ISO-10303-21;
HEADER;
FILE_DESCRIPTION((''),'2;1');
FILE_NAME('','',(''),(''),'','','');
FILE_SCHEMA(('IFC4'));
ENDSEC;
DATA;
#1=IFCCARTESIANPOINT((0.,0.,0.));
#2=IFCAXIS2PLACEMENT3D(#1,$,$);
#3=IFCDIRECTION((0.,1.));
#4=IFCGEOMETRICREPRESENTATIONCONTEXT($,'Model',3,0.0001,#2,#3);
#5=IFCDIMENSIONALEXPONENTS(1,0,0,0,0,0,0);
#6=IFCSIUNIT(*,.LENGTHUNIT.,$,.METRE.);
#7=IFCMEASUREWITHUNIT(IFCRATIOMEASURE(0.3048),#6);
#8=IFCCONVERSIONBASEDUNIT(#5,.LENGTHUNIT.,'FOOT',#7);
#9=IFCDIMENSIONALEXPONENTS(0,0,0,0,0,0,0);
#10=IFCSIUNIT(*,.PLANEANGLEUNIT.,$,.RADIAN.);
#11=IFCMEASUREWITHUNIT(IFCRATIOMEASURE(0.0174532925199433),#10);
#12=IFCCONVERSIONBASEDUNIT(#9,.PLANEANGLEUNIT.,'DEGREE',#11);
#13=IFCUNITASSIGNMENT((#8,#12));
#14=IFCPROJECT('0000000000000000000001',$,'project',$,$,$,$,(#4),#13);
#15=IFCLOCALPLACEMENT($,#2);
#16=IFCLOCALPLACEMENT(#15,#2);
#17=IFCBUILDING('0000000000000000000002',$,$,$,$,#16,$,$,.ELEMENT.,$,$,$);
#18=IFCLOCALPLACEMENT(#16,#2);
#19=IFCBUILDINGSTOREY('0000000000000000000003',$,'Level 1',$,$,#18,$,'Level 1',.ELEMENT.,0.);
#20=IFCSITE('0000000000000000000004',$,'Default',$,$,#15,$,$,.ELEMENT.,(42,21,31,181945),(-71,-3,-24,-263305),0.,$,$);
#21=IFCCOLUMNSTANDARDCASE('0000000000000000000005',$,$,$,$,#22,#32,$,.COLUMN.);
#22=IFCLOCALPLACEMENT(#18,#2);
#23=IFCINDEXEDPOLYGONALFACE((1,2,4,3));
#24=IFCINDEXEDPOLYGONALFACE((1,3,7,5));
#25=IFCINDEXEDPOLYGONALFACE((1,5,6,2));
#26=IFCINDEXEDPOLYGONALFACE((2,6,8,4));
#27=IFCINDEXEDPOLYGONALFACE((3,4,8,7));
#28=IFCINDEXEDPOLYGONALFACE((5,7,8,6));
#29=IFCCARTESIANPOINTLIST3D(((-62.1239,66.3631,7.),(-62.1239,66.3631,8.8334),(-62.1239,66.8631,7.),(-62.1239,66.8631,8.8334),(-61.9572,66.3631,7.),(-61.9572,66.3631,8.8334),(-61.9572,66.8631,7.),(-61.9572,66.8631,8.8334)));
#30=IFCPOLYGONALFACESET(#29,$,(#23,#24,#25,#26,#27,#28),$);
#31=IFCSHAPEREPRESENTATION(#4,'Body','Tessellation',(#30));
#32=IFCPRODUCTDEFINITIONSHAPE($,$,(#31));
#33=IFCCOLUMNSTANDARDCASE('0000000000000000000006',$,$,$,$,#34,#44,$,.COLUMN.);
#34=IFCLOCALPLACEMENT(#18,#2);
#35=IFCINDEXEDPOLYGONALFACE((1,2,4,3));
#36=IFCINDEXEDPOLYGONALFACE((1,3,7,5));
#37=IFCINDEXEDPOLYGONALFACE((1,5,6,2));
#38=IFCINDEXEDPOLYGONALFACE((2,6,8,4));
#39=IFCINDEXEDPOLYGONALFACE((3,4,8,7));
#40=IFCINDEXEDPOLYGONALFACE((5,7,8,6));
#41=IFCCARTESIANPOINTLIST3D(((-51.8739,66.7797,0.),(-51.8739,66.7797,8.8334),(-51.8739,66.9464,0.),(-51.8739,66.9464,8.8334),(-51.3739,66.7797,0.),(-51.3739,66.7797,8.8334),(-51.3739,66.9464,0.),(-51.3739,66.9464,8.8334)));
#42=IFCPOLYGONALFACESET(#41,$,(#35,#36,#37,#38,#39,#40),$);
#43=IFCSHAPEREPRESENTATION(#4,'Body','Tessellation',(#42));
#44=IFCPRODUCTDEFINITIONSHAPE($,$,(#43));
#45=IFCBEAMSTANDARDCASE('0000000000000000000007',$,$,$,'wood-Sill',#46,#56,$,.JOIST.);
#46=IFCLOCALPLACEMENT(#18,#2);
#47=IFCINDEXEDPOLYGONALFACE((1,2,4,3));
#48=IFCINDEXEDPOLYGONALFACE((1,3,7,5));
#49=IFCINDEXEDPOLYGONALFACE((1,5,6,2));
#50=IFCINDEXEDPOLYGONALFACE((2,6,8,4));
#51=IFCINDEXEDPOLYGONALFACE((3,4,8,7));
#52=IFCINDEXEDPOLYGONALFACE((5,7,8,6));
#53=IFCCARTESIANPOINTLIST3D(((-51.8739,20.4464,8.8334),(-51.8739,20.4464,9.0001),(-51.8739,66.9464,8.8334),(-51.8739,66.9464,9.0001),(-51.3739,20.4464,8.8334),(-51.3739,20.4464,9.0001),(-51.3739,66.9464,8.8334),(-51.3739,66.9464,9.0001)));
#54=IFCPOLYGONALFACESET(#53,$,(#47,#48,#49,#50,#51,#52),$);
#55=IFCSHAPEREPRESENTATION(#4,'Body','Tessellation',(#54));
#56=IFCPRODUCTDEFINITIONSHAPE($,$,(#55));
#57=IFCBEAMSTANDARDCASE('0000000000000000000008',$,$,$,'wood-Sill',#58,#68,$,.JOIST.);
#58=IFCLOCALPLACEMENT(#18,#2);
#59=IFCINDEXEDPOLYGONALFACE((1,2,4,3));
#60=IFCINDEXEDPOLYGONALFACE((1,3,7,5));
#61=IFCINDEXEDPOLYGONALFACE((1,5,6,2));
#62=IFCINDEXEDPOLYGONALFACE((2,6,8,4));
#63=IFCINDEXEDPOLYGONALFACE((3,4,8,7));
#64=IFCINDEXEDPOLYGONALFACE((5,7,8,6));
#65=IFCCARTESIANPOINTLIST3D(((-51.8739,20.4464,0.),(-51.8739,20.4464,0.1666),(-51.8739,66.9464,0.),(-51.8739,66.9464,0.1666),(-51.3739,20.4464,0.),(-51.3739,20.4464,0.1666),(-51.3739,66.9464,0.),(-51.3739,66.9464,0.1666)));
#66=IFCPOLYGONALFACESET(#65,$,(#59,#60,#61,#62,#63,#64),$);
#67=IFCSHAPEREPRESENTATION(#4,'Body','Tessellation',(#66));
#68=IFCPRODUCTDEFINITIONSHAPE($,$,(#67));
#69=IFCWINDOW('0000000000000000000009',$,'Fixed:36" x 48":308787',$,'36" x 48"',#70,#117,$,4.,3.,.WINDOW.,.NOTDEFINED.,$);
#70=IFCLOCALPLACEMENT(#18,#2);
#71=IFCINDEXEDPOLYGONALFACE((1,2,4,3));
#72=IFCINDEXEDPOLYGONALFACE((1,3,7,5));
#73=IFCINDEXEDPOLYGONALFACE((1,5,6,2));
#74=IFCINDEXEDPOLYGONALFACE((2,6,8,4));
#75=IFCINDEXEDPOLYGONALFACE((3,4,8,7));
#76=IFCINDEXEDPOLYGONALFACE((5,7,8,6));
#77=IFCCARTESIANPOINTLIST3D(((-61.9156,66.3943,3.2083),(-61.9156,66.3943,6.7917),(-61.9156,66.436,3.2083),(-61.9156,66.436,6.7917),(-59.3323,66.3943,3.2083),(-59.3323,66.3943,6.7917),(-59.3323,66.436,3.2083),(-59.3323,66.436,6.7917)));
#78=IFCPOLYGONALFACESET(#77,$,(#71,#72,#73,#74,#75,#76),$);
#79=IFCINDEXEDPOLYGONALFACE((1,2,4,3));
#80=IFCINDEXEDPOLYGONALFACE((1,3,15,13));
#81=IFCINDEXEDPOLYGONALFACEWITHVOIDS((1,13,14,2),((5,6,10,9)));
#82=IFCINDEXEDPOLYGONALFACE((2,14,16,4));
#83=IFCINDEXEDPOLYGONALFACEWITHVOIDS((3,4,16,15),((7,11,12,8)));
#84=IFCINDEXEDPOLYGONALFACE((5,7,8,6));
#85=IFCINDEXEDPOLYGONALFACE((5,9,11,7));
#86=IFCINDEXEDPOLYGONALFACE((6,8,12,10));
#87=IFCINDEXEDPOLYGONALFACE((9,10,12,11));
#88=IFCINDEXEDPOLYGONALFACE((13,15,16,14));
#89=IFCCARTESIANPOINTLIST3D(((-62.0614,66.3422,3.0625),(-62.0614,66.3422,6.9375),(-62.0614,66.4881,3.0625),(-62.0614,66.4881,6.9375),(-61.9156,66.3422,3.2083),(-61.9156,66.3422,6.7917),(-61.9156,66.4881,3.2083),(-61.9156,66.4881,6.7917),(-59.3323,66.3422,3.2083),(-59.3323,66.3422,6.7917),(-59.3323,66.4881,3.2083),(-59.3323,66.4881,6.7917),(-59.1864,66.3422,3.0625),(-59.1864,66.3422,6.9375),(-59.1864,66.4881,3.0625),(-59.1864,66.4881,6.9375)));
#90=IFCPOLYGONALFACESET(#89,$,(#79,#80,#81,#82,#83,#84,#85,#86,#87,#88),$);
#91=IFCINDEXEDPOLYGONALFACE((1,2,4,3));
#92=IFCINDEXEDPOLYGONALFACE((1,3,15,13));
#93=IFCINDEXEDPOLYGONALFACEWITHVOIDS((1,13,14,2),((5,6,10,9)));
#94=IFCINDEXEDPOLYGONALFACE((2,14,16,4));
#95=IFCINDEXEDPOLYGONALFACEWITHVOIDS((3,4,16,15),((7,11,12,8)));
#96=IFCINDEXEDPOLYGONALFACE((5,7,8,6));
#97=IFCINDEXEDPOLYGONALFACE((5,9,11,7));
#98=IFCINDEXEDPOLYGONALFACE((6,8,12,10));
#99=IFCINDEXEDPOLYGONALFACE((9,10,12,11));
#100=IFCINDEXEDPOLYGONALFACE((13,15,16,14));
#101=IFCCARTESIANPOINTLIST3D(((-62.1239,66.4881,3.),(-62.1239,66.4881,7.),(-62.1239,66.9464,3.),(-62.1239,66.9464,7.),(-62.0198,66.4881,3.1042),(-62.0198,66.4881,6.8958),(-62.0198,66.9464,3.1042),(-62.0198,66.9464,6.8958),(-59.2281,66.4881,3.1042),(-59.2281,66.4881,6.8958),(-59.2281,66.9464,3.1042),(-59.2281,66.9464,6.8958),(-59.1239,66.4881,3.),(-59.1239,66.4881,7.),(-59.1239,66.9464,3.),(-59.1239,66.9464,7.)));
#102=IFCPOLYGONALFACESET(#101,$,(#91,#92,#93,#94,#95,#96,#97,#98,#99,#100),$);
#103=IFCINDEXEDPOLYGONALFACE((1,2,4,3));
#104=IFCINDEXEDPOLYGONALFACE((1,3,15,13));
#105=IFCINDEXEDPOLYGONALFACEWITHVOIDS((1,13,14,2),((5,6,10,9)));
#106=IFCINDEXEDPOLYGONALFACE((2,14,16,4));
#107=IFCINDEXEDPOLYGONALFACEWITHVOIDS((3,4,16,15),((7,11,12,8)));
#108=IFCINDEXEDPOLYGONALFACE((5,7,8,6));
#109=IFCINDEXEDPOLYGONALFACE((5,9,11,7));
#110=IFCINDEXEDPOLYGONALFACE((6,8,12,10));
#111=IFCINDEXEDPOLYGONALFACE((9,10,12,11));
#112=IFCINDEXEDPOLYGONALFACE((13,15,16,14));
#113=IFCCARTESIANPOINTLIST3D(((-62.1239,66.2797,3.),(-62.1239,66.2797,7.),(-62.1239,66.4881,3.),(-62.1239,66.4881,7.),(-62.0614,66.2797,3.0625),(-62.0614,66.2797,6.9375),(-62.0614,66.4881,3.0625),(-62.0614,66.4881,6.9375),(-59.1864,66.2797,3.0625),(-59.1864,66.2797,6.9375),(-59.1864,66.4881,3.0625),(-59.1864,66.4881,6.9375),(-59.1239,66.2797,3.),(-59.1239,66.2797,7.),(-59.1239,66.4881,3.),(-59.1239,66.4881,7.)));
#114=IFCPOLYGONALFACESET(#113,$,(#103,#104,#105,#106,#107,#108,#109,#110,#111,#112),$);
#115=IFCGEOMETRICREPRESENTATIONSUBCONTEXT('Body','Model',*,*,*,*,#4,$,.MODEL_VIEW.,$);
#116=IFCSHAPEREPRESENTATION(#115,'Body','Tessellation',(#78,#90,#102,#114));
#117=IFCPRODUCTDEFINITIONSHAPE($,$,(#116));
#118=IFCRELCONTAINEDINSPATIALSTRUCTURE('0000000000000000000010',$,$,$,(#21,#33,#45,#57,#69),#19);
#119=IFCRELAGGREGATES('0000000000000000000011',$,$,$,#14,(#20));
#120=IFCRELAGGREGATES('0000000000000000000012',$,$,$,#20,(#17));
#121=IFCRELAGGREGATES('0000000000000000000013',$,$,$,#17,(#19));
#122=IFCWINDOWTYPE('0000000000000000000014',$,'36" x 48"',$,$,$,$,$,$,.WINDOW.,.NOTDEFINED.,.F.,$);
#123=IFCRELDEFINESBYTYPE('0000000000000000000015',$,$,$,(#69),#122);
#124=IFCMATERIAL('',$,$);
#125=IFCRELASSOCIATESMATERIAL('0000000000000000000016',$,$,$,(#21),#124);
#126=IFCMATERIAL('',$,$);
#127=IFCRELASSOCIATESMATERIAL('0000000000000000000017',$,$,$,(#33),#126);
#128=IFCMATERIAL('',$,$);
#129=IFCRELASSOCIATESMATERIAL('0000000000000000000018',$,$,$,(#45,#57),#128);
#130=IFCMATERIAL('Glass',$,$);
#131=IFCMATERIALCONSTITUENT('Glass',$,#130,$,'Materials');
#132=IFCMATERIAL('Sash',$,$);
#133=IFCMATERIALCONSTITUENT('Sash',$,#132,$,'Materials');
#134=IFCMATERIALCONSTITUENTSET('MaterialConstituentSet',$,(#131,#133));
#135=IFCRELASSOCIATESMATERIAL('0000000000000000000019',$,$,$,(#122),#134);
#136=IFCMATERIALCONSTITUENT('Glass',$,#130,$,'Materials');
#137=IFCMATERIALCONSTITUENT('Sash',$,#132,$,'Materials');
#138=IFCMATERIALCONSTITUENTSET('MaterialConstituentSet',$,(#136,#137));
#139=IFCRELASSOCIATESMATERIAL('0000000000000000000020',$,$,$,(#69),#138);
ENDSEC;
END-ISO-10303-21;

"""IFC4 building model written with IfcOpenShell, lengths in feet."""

from ifc_helpers import new_model, entity, si_unit, converted_unit, direction, frame, frame_2d, origin, origin_with_axes, place, context, subcontext, project, spatial, polyline, rectangle, outline, extrude, source, transform, mapped, material, constituent, constituent_set, type_object, type_shapes, element, save


model = new_model("IFC4")

# Units and contexts
model_context = context("Model", 3, precision=0.0001, world=origin(), true_north=direction((0.0, 1.0)))
body_context = subcontext(model_context, "Body", "Model", "MODEL_VIEW")
ifc_project = project(units=[converted_unit("LENGTHUNIT", "FOOT", entity("IfcRatioMeasure", 0.3048), si_unit("LENGTHUNIT", "METRE"), dimensions=[1, 0, 0, 0, 0, 0, 0]), converted_unit("PLANEANGLEUNIT", "DEGREE", entity("IfcRatioMeasure", 0.0174532925199433), si_unit("PLANEANGLEUNIT", "RADIAN"), dimensions=[0, 0, 0, 0, 0, 0, 0])], contexts=[model_context])

# Site, building, storey
site_placement = place(None, origin())
site = spatial("IfcSite", under=ifc_project, at=site_placement, Name="Default", CompositionType="ELEMENT", RefLatitude=(42, 21, 31, 181945), RefLongitude=(-71, -3, -24, -263305), RefElevation=0.0)
building_placement = place(site_placement, origin())
building = spatial("IfcBuilding", under=site, at=building_placement, CompositionType="ELEMENT")
storey_placement = place(building_placement, origin())
storey = spatial("IfcBuildingStorey", under=building, at=storey_placement, Name="Level 1", LongName="Level 1", CompositionType="ELEMENT", Elevation=0.0)

# Columns
ifc_material_1 = material(Name="")
placement_1 = place(storey_placement, frame((-69.9573, 66.6131, 0.0)))
ifc_material_2 = material(Name="")
for number, where, z_axis, x_axis in (
    (1, (7.9167, 0.0, 7.0), (0.0, 0.0, 1.0), (1.0, 0.0, 0.0)),
):
    element("IfcColumnStandardCase", number, at=place(placement_1, frame(where, z_axis=z_axis, x_axis=x_axis)), inside=storey, material=ifc_material_2, PredefinedType="COLUMN", context=model_context, shape_type="SweptSolid", body=[
        extrude(rectangle(XDim=0.1667, YDim=0.5), origin(), (0.0, 0.0, 1.0), 1.8334),
    ])
placement_2 = place(storey_placement, frame((-51.6239, 66.9464, 0.0), z_axis=(0.0, 0.0, 1.0), x_axis=(0.0, -1.0, 0.0)))
for number, where, z_axis, x_axis in (
    (2, (0.0833, 0.0, 0.0), (0.0, 0.0, 1.0), (1.0, 0.0, 0.0)),
):
    element("IfcColumnStandardCase", number, at=place(placement_2, frame(where, z_axis=z_axis, x_axis=x_axis)), inside=storey, material=ifc_material_1, PredefinedType="COLUMN", context=model_context, shape_type="SweptSolid", body=[
        extrude(rectangle(XDim=0.1667, YDim=0.5), origin(), (0.0, 0.0, 1.0), 8.8334),
    ])

# Beams
ifc_material_3 = material(Name="")
for number, where, z_axis, x_axis in (
    (3, (0.0, 0.0, 8.9167), (1.0, 0.0, 0.0), (0.0, 0.0, 1.0)),
    (4, (0.0, 0.0, 0.0833), (1.0, 0.0, 0.0), (0.0, 0.0, 1.0)),
):
    element("IfcBeamStandardCase", number, at=place(placement_2, frame(where, z_axis=z_axis, x_axis=x_axis)), inside=storey, material=ifc_material_3, ObjectType="wood-Sill", PredefinedType="JOIST", context=model_context, shape_type="SweptSolid", body=[
        extrude(rectangle(XDim=0.1667, YDim=0.5), origin_with_axes(), (0.0, 0.0, 1.0), 46.5),
    ])

# Window
ifc_material_4 = material(Name="Glass")
ifc_constituent_1 = constituent(ifc_material_4, Name="Glass", Category="Materials")
ifc_material_5 = material(Name="Sash")
ifc_constituent_2 = constituent(ifc_material_5, Name="Sash", Category="Materials")
ifc_constituent_set_1 = constituent_set(constituents=[ifc_constituent_1, ifc_constituent_2], Name="MaterialConstituentSet")
ifc_constituent_3 = constituent(ifc_material_4, Name="Glass", Category="Materials")
ifc_constituent_4 = constituent(ifc_material_5, Name="Sash", Category="Materials")
ifc_constituent_set_2 = constituent_set(constituents=[ifc_constituent_3, ifc_constituent_4], Name="MaterialConstituentSet")
window_type = type_object("IfcWindowType", Name="36\" x 48\"", ParameterTakesPrecedence=False, PartitioningType="NOTDEFINED", PredefinedType="WINDOW", material=ifc_constituent_set_2)
shared_shape = source(origin(), body_context, "Body", "SweptSolid", [
    extrude(rectangle(XDim=0.0417, YDim=2.5833, at=frame_2d((0.0, 0.0), x_axis=(1.0, 0.0))), frame((1.5, 0.5312, 0.2083), z_axis=(0.0, 0.0, 1.0), x_axis=(0.0, 1.0, 0.0)), (0.0, 0.0, 1.0), 3.5833),
    extrude(outline(polyline([(-1.4375, -1.9375), (1.4375, -1.9375), (1.4375, 1.9375), (-1.4375, 1.9375), (-1.4375, -1.9375)]), holes=[polyline([(-1.2917, -1.7917), (-1.2917, 1.7917), (1.2917, 1.7917), (1.2917, -1.7917), (-1.2917, -1.7917)])]), frame((1.5, 0.4583, 2.0), z_axis=(0.0, 1.0, 0.0), x_axis=(1.0, 0.0, 0.0)), (0.0, 0.0, 1.0), 0.1458),
    extrude(outline(polyline([(-1.5, -2.0), (1.5, -2.0), (1.5, 2.0), (-1.5, 2.0), (-1.5, -2.0)]), holes=[polyline([(-1.3958, -1.8958), (-1.3958, 1.8958), (1.3958, 1.8958), (1.3958, -1.8958), (-1.3958, -1.8958)])]), frame((1.5, 0.0, 2.0), z_axis=(0.0, 1.0, 0.0), x_axis=(1.0, 0.0, 0.0)), (0.0, 0.0, 1.0), 0.4583),
    extrude(outline(polyline([(-2.0, -1.5), (2.0, -1.5), (2.0, 1.5), (-2.0, 1.5), (-2.0, -1.5)]), holes=[polyline([(-1.9375, -1.4375), (-1.9375, 1.4375), (1.9375, 1.4375), (1.9375, -1.4375), (-1.9375, -1.4375)])]), frame((1.5, 0.4583, 2.0), z_axis=(0.0, 1.0, 0.0), x_axis=(0.0, 0.0, -1.0)), (0.0, 0.0, 1.0), 0.2083),
])
type_shapes(window_type, [shared_shape])
placement_3 = place(placement_1, frame((10.8333, 0.3333, 3.0)))
window_placement = place(placement_3, frame((0.0, 0.0, 0.0), z_axis=(0.0, 0.0, 1.0), x_axis=(-1.0, 0.0, 0.0)))
element("IfcWindow", 5, at=window_placement, inside=storey, type_object=window_type, material=ifc_constituent_set_1, Name="Fixed:36\" x 48\":308787", ObjectType="36\" x 48\"", OverallHeight=4.0, OverallWidth=3.0, PartitioningType="NOTDEFINED", PredefinedType="WINDOW", context=body_context, shape_type="MappedRepresentation", body=[
    mapped(shared_shape, transform((0.0, 0.0, 0.0), scale=1.0)),
])

save(model, "model.ifc")
